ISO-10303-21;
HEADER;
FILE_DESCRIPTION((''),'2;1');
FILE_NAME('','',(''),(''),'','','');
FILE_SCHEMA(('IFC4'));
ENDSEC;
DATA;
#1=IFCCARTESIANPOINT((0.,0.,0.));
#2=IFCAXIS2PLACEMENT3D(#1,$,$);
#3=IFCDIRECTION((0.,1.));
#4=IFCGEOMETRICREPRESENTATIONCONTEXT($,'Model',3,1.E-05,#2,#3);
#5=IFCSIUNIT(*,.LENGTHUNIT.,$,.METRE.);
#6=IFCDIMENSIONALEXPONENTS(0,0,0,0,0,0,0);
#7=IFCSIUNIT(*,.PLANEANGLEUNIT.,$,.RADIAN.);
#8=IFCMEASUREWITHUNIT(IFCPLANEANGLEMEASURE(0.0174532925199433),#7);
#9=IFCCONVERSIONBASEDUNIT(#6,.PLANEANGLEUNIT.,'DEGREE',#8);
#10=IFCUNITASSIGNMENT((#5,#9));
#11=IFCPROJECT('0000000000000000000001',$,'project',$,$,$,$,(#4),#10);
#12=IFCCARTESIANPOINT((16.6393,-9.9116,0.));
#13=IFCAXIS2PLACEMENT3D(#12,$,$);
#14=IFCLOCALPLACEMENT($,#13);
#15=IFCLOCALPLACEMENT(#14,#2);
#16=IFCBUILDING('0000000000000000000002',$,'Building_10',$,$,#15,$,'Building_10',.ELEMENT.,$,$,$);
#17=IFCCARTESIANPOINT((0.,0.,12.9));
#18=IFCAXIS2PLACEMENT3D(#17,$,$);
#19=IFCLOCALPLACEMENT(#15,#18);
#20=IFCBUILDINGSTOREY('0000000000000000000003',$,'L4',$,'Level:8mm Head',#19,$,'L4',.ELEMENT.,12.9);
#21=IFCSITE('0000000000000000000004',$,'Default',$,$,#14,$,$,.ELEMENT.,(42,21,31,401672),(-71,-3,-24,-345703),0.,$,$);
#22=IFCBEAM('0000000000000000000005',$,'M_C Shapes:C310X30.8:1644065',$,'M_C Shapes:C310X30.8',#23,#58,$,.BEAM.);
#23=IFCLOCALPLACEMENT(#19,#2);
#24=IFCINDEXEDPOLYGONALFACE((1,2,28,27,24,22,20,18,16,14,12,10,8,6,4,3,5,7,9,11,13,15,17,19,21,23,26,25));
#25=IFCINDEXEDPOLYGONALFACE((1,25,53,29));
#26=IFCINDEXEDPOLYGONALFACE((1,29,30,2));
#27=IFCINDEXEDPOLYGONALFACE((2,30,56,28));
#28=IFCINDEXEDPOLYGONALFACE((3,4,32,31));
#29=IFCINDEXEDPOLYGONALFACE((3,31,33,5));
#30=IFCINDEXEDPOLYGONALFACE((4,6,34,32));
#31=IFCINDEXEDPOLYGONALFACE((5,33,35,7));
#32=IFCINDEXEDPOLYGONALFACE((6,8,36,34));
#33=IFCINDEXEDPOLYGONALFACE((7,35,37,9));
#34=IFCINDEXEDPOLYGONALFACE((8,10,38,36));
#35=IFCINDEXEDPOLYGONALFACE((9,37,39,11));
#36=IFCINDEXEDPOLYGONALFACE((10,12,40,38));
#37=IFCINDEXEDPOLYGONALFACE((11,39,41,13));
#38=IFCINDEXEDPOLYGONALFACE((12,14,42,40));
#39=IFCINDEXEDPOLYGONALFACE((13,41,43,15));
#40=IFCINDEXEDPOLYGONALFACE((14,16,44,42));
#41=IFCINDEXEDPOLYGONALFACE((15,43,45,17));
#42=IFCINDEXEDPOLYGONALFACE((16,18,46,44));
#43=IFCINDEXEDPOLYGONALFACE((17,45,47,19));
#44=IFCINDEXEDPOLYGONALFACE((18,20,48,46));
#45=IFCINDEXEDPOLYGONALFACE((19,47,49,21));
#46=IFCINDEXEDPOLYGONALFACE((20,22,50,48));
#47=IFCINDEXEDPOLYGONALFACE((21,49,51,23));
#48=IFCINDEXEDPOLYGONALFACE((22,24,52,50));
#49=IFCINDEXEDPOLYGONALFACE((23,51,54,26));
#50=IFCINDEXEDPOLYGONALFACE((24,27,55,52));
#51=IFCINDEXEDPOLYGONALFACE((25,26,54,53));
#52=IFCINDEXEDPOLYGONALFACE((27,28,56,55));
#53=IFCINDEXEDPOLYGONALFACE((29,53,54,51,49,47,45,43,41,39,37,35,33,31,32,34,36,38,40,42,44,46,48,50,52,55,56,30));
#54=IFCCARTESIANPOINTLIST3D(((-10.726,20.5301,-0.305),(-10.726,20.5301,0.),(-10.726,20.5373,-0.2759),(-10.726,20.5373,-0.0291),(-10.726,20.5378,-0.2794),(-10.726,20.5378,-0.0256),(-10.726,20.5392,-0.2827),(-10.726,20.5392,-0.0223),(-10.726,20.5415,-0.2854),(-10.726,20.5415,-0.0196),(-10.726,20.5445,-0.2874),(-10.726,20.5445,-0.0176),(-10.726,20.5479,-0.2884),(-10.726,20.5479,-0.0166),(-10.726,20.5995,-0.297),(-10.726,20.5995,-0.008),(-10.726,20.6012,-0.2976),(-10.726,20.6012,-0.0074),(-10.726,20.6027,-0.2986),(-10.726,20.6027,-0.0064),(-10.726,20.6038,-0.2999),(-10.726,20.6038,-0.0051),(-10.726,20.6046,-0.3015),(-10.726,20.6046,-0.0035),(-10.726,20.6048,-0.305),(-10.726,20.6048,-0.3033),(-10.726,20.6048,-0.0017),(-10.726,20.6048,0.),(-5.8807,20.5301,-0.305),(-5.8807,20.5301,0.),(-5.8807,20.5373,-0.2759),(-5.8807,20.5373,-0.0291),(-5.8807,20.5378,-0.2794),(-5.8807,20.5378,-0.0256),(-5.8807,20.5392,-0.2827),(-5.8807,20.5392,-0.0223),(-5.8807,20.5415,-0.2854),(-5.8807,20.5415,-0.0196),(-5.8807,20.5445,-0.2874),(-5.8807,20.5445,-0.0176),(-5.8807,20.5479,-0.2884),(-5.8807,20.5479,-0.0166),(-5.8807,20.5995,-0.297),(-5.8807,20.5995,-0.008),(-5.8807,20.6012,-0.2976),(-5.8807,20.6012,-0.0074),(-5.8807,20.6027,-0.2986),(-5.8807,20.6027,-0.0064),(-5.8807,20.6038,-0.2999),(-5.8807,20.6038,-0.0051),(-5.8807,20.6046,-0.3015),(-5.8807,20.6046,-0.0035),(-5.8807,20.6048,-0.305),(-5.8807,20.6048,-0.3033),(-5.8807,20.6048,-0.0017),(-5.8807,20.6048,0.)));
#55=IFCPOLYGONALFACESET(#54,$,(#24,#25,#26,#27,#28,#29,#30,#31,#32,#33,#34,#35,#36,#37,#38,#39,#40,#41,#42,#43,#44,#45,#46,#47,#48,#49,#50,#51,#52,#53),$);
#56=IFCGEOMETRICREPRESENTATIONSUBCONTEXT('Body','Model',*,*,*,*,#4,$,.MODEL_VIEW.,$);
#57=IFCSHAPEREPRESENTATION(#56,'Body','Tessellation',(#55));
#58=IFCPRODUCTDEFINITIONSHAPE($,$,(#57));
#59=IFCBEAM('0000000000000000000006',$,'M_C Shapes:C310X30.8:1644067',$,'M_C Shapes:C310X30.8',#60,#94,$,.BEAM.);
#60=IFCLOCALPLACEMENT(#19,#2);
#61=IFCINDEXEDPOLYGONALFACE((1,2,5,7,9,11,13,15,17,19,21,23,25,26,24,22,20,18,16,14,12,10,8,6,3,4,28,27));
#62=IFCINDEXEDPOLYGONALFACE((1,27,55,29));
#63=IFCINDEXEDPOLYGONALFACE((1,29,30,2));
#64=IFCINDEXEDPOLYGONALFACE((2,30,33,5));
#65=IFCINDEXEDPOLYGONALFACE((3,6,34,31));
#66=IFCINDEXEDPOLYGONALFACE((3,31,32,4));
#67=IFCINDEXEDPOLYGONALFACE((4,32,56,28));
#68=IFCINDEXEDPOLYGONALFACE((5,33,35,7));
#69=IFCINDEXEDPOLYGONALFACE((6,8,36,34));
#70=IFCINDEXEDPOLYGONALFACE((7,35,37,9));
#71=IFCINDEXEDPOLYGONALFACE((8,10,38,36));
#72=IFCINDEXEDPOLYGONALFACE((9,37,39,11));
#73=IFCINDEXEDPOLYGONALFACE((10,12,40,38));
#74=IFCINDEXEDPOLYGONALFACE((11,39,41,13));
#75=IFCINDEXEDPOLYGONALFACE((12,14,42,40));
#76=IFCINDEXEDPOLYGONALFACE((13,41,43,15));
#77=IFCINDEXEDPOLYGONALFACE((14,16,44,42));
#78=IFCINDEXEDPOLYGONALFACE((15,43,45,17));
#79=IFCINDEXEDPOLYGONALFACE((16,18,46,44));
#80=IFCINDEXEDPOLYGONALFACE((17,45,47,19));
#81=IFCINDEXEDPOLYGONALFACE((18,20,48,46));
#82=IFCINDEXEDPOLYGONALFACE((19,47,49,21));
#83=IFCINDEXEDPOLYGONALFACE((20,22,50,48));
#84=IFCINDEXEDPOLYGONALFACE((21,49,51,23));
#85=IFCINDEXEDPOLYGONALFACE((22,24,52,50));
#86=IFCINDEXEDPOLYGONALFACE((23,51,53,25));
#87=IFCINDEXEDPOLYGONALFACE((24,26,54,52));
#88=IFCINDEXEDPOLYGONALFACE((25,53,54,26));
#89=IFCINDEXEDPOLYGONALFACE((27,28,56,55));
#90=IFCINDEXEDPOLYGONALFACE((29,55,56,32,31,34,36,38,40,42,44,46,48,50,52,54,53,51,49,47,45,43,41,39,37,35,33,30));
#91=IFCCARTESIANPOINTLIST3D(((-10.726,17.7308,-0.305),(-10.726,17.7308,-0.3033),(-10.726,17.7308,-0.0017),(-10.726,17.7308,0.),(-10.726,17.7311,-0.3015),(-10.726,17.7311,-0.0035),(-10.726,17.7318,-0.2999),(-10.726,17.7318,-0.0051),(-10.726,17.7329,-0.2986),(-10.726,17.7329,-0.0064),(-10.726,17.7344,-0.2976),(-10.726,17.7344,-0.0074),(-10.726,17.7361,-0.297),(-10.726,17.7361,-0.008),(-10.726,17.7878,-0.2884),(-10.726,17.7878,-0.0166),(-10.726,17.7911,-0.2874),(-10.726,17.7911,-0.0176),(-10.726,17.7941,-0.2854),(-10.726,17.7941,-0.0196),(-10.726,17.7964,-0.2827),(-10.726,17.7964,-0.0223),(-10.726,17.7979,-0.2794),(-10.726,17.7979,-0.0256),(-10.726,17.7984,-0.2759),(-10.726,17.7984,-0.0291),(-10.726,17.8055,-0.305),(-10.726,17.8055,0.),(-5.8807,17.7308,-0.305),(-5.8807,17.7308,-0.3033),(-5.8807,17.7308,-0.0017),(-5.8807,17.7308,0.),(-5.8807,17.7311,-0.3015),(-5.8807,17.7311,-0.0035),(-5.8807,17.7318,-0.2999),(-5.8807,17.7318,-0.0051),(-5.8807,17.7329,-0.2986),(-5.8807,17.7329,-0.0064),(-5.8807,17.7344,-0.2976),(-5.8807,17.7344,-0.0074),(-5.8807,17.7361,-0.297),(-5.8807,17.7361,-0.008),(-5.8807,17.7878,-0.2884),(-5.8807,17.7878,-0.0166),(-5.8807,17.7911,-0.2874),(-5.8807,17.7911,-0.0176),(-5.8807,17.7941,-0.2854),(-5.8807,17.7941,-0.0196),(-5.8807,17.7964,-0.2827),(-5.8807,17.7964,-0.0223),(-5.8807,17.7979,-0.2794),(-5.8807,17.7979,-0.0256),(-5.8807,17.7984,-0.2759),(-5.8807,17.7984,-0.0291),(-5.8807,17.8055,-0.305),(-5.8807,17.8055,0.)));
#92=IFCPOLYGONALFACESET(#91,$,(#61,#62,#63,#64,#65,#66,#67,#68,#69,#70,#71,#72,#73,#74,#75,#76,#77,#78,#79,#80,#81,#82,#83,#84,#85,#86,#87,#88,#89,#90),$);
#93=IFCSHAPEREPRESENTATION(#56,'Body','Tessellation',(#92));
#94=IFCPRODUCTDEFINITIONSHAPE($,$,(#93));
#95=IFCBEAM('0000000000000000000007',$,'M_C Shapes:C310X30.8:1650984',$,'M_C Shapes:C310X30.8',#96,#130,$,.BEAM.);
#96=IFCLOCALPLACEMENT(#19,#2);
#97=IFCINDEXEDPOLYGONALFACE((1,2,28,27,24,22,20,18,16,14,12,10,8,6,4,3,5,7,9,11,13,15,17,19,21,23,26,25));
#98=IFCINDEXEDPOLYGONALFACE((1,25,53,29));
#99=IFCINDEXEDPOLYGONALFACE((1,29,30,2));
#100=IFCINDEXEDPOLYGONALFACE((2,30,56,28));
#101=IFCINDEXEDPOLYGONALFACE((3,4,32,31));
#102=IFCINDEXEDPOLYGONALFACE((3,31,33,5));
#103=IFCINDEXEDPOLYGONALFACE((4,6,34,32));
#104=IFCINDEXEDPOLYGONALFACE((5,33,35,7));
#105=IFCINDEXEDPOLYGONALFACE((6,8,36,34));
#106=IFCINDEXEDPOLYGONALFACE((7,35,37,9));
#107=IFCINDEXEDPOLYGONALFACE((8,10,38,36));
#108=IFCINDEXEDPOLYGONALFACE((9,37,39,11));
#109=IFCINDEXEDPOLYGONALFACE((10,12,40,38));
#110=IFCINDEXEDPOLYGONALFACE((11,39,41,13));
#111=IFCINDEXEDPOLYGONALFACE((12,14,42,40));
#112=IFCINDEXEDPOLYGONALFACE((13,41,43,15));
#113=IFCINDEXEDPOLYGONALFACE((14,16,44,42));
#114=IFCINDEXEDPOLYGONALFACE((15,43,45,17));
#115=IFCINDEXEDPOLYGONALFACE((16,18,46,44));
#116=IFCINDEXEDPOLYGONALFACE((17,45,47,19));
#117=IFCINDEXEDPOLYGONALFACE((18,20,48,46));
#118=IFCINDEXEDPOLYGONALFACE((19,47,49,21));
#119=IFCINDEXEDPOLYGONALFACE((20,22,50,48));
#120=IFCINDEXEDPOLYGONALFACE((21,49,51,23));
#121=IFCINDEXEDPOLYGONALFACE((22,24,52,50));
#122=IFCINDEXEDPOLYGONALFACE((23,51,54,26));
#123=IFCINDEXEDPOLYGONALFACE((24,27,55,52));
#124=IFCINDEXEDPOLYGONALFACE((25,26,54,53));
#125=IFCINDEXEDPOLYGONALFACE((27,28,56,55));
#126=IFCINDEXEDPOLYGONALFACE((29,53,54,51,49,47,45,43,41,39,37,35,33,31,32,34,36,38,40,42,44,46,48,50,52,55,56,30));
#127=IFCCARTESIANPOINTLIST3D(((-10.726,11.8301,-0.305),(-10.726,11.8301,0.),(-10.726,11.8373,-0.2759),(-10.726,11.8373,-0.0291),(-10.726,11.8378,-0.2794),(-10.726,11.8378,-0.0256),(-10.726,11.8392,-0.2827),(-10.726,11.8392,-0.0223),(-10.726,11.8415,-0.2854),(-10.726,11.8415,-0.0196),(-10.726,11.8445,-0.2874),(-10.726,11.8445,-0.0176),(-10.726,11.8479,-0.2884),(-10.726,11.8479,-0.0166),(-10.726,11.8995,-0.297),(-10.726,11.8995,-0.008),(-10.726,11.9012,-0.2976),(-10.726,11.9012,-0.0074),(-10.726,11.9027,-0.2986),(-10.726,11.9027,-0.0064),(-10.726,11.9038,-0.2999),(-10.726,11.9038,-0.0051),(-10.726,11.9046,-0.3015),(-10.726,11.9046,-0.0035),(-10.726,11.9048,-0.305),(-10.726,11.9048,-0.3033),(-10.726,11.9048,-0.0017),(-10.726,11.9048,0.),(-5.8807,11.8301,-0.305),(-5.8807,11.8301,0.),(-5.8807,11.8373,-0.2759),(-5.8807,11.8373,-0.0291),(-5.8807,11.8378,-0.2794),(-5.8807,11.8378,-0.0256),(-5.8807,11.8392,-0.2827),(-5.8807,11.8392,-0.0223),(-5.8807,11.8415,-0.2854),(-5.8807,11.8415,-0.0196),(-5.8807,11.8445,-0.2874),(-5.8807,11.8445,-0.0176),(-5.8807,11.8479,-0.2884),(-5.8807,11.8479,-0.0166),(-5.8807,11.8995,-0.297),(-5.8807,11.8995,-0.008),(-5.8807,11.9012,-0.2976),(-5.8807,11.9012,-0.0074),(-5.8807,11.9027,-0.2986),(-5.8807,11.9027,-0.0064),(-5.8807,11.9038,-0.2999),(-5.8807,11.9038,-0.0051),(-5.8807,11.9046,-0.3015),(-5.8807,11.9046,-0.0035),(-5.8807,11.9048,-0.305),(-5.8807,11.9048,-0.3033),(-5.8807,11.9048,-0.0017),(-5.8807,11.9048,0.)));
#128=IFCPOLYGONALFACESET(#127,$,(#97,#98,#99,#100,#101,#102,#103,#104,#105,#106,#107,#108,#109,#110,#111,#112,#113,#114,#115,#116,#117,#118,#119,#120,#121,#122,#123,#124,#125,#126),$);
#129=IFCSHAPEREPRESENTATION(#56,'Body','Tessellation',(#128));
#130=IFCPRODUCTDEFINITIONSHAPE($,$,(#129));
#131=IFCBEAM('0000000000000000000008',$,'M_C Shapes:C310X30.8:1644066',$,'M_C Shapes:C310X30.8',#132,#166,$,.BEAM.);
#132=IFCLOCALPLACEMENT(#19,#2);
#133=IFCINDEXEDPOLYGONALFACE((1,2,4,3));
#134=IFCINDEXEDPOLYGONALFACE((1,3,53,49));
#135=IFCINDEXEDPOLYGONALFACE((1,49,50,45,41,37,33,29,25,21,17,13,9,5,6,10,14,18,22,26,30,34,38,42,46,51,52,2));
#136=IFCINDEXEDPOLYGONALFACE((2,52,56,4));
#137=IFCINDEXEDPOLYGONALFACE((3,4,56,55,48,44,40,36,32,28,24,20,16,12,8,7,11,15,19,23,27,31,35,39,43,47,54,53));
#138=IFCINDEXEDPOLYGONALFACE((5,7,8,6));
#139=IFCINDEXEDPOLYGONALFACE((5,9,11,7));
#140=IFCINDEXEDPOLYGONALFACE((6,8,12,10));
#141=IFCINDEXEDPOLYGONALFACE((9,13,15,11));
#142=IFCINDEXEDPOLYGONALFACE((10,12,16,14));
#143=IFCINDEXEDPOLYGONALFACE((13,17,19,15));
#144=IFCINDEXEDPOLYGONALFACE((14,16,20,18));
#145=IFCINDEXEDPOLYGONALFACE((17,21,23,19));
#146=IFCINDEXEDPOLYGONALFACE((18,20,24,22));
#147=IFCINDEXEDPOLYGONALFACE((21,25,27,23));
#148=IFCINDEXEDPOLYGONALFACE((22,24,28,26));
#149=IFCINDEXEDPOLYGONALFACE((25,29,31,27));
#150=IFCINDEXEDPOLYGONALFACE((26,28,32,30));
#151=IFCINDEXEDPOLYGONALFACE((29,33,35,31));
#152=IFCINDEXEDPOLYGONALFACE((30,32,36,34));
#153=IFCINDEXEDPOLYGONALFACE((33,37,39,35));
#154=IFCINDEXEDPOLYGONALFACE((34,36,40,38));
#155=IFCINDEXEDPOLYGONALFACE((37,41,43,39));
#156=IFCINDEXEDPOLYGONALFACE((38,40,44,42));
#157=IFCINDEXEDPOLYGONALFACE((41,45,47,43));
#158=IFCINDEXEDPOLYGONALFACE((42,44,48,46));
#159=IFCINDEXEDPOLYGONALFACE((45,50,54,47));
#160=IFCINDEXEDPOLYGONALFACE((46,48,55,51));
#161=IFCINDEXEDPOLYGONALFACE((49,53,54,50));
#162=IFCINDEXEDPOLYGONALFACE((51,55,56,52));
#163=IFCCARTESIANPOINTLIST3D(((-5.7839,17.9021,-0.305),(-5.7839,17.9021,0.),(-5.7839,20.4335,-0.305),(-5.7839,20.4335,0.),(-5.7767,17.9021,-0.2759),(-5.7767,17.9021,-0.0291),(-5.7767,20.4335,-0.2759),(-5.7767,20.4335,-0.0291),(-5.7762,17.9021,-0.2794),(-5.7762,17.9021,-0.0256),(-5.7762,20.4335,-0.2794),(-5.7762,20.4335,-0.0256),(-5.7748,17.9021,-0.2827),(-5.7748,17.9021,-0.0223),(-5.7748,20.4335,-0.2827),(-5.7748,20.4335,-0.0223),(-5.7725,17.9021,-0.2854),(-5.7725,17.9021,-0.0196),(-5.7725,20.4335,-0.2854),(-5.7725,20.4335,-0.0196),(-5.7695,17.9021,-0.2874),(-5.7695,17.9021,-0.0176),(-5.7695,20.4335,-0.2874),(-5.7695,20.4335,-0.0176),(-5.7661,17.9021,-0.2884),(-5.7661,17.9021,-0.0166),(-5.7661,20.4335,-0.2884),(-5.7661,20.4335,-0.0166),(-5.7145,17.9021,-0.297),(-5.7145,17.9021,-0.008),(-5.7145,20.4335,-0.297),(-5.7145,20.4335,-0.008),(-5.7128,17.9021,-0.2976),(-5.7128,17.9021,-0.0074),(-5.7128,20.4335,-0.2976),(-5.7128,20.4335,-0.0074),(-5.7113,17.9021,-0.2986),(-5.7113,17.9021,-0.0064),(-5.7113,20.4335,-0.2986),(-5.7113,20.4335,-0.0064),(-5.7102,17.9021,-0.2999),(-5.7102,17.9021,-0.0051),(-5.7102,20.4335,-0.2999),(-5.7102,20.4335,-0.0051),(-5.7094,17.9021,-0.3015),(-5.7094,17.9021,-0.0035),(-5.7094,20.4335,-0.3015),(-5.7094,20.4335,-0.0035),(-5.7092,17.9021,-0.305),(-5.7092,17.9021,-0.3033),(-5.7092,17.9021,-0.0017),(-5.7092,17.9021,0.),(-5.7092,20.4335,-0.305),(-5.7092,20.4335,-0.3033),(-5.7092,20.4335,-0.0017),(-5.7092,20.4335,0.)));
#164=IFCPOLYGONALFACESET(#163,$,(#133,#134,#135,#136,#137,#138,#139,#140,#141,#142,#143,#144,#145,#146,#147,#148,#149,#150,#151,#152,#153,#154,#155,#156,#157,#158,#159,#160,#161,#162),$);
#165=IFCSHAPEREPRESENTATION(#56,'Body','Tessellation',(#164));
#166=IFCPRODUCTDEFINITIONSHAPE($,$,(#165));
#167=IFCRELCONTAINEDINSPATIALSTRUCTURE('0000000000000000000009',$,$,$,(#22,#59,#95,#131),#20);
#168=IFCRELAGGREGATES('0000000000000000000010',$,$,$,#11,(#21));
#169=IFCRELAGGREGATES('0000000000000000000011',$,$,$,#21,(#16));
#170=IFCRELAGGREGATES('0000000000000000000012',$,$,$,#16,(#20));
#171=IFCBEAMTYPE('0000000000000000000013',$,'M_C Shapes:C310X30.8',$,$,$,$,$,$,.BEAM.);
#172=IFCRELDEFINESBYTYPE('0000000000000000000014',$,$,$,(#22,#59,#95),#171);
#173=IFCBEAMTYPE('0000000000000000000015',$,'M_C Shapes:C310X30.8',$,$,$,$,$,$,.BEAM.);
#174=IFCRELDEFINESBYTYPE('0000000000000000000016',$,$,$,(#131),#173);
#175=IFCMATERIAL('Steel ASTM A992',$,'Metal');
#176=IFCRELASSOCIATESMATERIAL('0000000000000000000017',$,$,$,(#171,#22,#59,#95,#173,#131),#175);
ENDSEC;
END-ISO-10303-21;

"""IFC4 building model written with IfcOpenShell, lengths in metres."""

from ifc_helpers import new_model, entity, si_unit, converted_unit, direction, frame, origin, place, context, subcontext, project, spatial, line, arc, indexed_curve, outline, extrude, source, transform, mapped, material, type_object, type_shapes, element, save


model = new_model("IFC4")

# Units and contexts
model_context = context("Model", 3, precision=1e-05, world=origin(), true_north=direction((0.0, 1.0)))
body_context = subcontext(model_context, "Body", "Model", "MODEL_VIEW")
ifc_project = project(units=[si_unit("LENGTHUNIT", "METRE"), converted_unit("PLANEANGLEUNIT", "DEGREE", entity("IfcPlaneAngleMeasure", 0.0174532925199433), si_unit("PLANEANGLEUNIT", "RADIAN"), dimensions=[0, 0, 0, 0, 0, 0, 0])], contexts=[model_context])

# Site, building, storey
site_placement = place(None, frame((16.6393, -9.9116, 0.0)))
site = spatial("IfcSite", under=ifc_project, at=site_placement, Name="Default", CompositionType="ELEMENT", RefLatitude=(42, 21, 31, 401672), RefLongitude=(-71, -3, -24, -345703), RefElevation=0.0)
building_placement = place(site_placement, origin())
building = spatial("IfcBuilding", under=site, at=building_placement, Name="Building_10", LongName="Building_10", CompositionType="ELEMENT")
storey_placement = place(building_placement, frame((0.0, 0.0, 12.9)))
storey = spatial("IfcBuildingStorey", under=building, at=storey_placement, Name="L4", ObjectType="Level:8mm Head", LongName="L4", CompositionType="ELEMENT", Elevation=12.9)

# Shared definitions
ifc_material_1 = material(Name="Steel ASTM A992", Category="Metal")

# Beams
beam_type_1 = type_object("IfcBeamType", Name="M_C Shapes:C310X30.8", PredefinedType="BEAM", material=ifc_material_1)
shared_shape_1 = source(origin(), body_context, "Body", "SweptSolid", [
    extrude(outline(indexed_curve([(-0.0406, -0.1525), (0.0341, -0.1525), (0.0341, -0.1508), (0.0326, -0.1467), (0.0288, -0.1445), (-0.0228, -0.1359), (-0.0305, -0.1316), (-0.0335, -0.1234), (-0.0335, 0.1234), (-0.0305, 0.1316), (-0.0228, 0.1359), (0.0288, 0.1445), (0.0326, 0.1467), (0.0341, 0.1508), (0.0341, 0.1525), (-0.0406, 0.1525)], segments=[line(1, 2, 3), arc(3, 4, 5), line(5, 6), arc(6, 7, 8), line(8, 9), arc(9, 10, 11), line(11, 12), arc(12, 13, 14), line(14, 15, 16, 1)], self_intersect=False)), frame((-2.4226, -0.0229, 0.0), z_axis=(1.0, 0.0, 0.0), x_axis=(0.0, -1.0, 0.0)), (0.0, 0.0, 1.0), 4.8453),
])
type_shapes(beam_type_1, [shared_shape_1])
beam_1_placement = place(storey_placement, frame((-8.3033, 20.5478, -0.1525), z_axis=(0.0, 0.0, 1.0), x_axis=(-1.0, 0.0, 0.0)))
element("IfcBeam", 1, at=beam_1_placement, inside=storey, type_object=beam_type_1, material=ifc_material_1, Name="M_C Shapes:C310X30.8:1644065", ObjectType="M_C Shapes:C310X30.8", PredefinedType="BEAM", context=body_context, shape_type="MappedRepresentation", body=[
    mapped(shared_shape_1, transform((0.0, 0.0, 0.0), scale=1.0)),
])
beam_2_placement = place(storey_placement, frame((-8.3033, 17.7878, -0.1525)))
element("IfcBeam", 2, at=beam_2_placement, inside=storey, type_object=beam_type_1, material=ifc_material_1, Name="M_C Shapes:C310X30.8:1644067", ObjectType="M_C Shapes:C310X30.8", PredefinedType="BEAM", context=body_context, shape_type="MappedRepresentation", body=[
    mapped(shared_shape_1, transform((0.0, 0.0, 0.0), scale=1.0)),
])
beam_3_placement = place(storey_placement, frame((-8.3033, 11.8478, -0.1525), z_axis=(0.0, 0.0, 1.0), x_axis=(-1.0, 0.0, 0.0)))
element("IfcBeam", 3, at=beam_3_placement, inside=storey, type_object=beam_type_1, material=ifc_material_1, Name="M_C Shapes:C310X30.8:1650984", ObjectType="M_C Shapes:C310X30.8", PredefinedType="BEAM", context=body_context, shape_type="MappedRepresentation", body=[
    mapped(shared_shape_1, transform((0.0, 0.0, 0.0), scale=1.0)),
])
beam_type_2 = type_object("IfcBeamType", Name="M_C Shapes:C310X30.8", PredefinedType="BEAM", material=ifc_material_1)
shared_shape_2 = source(origin(), body_context, "Body", "SweptSolid", [
    extrude(outline(indexed_curve([(-0.0406, -0.1525), (0.0341, -0.1525), (0.0341, -0.1508), (0.0326, -0.1467), (0.0288, -0.1445), (-0.0228, -0.1359), (-0.0305, -0.1316), (-0.0335, -0.1234), (-0.0335, 0.1234), (-0.0305, 0.1316), (-0.0228, 0.1359), (0.0288, 0.1445), (0.0326, 0.1467), (0.0341, 0.1508), (0.0341, 0.1525), (-0.0406, 0.1525)], segments=[line(1, 2, 3), arc(3, 4, 5), line(5, 6), arc(6, 7, 8), line(8, 9), arc(9, 10, 11), line(11, 12), arc(12, 13, 14), line(14, 15, 16, 1)], self_intersect=False)), frame((-1.2657, -0.0229, 0.0), z_axis=(1.0, 0.0, 0.0), x_axis=(0.0, -1.0, 0.0)), (0.0, 0.0, 1.0), 2.5314),
])
type_shapes(beam_type_2, [shared_shape_2])
for number, where, z_axis, x_axis, name in (
    (4, (-5.7662, 19.1678, -0.1525), (0.0, 0.0, 1.0), (0.0, 1.0, 0.0), "M_C Shapes:C310X30.8:1644066"),
):
    element("IfcBeam", number, at=place(storey_placement, frame(where, z_axis=z_axis, x_axis=x_axis)), inside=storey, type_object=beam_type_2, material=ifc_material_1, Name=name, ObjectType="M_C Shapes:C310X30.8", PredefinedType="BEAM", context=body_context, shape_type="MappedRepresentation", body=[
        mapped(shared_shape_2, transform((0.0, 0.0, 0.0), scale=1.0)),
    ])

save(model, "model.ifc")
